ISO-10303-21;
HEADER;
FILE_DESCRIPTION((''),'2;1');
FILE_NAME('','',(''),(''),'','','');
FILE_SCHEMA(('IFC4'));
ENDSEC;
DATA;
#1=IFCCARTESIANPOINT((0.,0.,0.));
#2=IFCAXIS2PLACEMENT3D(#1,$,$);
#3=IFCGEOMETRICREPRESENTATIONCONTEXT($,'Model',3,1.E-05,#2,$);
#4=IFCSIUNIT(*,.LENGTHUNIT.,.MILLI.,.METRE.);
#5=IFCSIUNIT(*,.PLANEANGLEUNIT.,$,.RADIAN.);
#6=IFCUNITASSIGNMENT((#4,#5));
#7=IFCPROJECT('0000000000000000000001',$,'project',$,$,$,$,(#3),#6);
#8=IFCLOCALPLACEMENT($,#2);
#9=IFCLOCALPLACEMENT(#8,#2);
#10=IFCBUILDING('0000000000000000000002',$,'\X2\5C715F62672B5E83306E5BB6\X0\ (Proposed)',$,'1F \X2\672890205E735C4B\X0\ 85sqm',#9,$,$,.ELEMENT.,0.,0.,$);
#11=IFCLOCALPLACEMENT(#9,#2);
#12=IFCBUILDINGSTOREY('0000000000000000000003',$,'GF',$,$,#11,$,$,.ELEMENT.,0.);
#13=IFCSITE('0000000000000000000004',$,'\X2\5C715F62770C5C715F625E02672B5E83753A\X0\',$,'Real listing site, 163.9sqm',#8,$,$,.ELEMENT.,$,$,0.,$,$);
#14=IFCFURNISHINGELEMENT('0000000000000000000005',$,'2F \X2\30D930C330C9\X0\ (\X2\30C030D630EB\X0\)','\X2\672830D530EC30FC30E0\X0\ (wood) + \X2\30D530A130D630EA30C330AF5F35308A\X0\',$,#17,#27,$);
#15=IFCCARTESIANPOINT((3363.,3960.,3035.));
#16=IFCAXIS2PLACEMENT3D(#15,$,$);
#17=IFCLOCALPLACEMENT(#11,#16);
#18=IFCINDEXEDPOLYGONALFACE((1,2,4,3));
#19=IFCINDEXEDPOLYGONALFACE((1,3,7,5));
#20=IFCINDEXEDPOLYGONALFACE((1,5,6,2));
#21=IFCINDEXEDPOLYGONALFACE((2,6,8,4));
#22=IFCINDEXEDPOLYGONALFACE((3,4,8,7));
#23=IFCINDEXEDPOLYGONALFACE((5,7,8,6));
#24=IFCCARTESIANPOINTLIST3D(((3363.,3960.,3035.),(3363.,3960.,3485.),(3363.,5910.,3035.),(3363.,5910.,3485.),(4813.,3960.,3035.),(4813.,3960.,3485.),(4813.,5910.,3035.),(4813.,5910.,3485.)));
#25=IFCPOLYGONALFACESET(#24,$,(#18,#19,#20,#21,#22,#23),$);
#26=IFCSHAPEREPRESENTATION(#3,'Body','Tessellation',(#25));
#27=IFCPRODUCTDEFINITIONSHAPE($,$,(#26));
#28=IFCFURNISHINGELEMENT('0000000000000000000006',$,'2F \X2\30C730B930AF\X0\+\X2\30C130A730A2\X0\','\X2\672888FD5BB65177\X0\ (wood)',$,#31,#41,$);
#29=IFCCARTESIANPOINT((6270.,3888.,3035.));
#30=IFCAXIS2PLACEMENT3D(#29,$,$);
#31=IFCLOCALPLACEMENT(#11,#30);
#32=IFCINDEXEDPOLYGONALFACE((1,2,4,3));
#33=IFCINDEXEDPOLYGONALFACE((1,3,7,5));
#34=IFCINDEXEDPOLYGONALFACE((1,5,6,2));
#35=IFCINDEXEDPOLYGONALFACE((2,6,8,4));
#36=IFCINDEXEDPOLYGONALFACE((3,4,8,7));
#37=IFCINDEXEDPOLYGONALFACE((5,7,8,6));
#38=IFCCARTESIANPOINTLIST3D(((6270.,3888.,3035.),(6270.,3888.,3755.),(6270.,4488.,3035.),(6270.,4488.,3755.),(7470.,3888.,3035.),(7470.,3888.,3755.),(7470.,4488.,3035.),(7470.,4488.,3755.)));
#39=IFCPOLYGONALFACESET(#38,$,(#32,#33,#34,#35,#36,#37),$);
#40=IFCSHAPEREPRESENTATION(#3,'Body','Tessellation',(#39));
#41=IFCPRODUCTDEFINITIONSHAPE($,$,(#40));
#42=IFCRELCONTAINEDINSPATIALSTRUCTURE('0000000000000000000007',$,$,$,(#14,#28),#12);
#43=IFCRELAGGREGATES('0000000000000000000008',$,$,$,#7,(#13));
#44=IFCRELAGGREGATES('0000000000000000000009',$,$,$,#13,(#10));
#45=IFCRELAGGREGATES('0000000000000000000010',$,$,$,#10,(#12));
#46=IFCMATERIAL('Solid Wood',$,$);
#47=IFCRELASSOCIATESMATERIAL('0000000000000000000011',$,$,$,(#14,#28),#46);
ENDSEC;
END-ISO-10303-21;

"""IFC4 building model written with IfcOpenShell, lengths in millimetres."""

from ifc_helpers import new_model, si_unit, frame, frame_2d, origin, place, context, project, spatial, rectangle, extrude, material, element, save


model = new_model("IFC4")

# Units and contexts
model_context = context("Model", 3, precision=1e-05, world=origin())
ifc_project = project(units=[si_unit("LENGTHUNIT", "METRE", prefix="MILLI"), si_unit("PLANEANGLEUNIT", "RADIAN")], contexts=[model_context])

# Site, building, storey
site_placement = place(None, origin())
site = spatial("IfcSite", under=ifc_project, at=site_placement, Name="山形県山形市末広町", ObjectType="Real listing site, 163.9sqm", CompositionType="ELEMENT", RefElevation=0.0)
building_placement = place(site_placement, origin())
building = spatial("IfcBuilding", under=site, at=building_placement, Name="山形末広の家 (Proposed)", ObjectType="1F 木造平屋 85sqm", CompositionType="ELEMENT", ElevationOfRefHeight=0.0, ElevationOfTerrain=0.0)
storey_placement = place(building_placement, origin())
storey = spatial("IfcBuildingStorey", under=building, at=storey_placement, Name="GF", CompositionType="ELEMENT", Elevation=0.0)

# Shared definitions
ifc_material_1 = material(Name="Solid Wood")

# Furnishing elements
furnishing_1_placement = place(storey_placement, frame((3363.0, 3960.0, 3035.0)))
element("IfcFurnishingElement", 1, at=furnishing_1_placement, inside=storey, material=ifc_material_1, Name="2F ベッド (ダブル)", Description="木フレーム (wood) + ファブリック張り", context=model_context, shape_type="SweptSolid", body=[
    extrude(rectangle(XDim=1450.0, YDim=1950.0, at=frame_2d((725.0, 975.0))), frame((3363.0, 3960.0, 3035.0)), (0.0, 0.0, 1.0), 450.0),
])
furnishing_2_placement = place(storey_placement, frame((6270.0, 3888.0, 3035.0)))
element("IfcFurnishingElement", 2, at=furnishing_2_placement, inside=storey, material=ifc_material_1, Name="2F デスク+チェア", Description="木製家具 (wood)", context=model_context, shape_type="SweptSolid", body=[
    extrude(rectangle(XDim=1200.0, YDim=600.0, at=frame_2d((600.0, 300.0))), frame((6270.0, 3888.0, 3035.0)), (0.0, 0.0, 1.0), 720.0),
])

save(model, "model.ifc")
